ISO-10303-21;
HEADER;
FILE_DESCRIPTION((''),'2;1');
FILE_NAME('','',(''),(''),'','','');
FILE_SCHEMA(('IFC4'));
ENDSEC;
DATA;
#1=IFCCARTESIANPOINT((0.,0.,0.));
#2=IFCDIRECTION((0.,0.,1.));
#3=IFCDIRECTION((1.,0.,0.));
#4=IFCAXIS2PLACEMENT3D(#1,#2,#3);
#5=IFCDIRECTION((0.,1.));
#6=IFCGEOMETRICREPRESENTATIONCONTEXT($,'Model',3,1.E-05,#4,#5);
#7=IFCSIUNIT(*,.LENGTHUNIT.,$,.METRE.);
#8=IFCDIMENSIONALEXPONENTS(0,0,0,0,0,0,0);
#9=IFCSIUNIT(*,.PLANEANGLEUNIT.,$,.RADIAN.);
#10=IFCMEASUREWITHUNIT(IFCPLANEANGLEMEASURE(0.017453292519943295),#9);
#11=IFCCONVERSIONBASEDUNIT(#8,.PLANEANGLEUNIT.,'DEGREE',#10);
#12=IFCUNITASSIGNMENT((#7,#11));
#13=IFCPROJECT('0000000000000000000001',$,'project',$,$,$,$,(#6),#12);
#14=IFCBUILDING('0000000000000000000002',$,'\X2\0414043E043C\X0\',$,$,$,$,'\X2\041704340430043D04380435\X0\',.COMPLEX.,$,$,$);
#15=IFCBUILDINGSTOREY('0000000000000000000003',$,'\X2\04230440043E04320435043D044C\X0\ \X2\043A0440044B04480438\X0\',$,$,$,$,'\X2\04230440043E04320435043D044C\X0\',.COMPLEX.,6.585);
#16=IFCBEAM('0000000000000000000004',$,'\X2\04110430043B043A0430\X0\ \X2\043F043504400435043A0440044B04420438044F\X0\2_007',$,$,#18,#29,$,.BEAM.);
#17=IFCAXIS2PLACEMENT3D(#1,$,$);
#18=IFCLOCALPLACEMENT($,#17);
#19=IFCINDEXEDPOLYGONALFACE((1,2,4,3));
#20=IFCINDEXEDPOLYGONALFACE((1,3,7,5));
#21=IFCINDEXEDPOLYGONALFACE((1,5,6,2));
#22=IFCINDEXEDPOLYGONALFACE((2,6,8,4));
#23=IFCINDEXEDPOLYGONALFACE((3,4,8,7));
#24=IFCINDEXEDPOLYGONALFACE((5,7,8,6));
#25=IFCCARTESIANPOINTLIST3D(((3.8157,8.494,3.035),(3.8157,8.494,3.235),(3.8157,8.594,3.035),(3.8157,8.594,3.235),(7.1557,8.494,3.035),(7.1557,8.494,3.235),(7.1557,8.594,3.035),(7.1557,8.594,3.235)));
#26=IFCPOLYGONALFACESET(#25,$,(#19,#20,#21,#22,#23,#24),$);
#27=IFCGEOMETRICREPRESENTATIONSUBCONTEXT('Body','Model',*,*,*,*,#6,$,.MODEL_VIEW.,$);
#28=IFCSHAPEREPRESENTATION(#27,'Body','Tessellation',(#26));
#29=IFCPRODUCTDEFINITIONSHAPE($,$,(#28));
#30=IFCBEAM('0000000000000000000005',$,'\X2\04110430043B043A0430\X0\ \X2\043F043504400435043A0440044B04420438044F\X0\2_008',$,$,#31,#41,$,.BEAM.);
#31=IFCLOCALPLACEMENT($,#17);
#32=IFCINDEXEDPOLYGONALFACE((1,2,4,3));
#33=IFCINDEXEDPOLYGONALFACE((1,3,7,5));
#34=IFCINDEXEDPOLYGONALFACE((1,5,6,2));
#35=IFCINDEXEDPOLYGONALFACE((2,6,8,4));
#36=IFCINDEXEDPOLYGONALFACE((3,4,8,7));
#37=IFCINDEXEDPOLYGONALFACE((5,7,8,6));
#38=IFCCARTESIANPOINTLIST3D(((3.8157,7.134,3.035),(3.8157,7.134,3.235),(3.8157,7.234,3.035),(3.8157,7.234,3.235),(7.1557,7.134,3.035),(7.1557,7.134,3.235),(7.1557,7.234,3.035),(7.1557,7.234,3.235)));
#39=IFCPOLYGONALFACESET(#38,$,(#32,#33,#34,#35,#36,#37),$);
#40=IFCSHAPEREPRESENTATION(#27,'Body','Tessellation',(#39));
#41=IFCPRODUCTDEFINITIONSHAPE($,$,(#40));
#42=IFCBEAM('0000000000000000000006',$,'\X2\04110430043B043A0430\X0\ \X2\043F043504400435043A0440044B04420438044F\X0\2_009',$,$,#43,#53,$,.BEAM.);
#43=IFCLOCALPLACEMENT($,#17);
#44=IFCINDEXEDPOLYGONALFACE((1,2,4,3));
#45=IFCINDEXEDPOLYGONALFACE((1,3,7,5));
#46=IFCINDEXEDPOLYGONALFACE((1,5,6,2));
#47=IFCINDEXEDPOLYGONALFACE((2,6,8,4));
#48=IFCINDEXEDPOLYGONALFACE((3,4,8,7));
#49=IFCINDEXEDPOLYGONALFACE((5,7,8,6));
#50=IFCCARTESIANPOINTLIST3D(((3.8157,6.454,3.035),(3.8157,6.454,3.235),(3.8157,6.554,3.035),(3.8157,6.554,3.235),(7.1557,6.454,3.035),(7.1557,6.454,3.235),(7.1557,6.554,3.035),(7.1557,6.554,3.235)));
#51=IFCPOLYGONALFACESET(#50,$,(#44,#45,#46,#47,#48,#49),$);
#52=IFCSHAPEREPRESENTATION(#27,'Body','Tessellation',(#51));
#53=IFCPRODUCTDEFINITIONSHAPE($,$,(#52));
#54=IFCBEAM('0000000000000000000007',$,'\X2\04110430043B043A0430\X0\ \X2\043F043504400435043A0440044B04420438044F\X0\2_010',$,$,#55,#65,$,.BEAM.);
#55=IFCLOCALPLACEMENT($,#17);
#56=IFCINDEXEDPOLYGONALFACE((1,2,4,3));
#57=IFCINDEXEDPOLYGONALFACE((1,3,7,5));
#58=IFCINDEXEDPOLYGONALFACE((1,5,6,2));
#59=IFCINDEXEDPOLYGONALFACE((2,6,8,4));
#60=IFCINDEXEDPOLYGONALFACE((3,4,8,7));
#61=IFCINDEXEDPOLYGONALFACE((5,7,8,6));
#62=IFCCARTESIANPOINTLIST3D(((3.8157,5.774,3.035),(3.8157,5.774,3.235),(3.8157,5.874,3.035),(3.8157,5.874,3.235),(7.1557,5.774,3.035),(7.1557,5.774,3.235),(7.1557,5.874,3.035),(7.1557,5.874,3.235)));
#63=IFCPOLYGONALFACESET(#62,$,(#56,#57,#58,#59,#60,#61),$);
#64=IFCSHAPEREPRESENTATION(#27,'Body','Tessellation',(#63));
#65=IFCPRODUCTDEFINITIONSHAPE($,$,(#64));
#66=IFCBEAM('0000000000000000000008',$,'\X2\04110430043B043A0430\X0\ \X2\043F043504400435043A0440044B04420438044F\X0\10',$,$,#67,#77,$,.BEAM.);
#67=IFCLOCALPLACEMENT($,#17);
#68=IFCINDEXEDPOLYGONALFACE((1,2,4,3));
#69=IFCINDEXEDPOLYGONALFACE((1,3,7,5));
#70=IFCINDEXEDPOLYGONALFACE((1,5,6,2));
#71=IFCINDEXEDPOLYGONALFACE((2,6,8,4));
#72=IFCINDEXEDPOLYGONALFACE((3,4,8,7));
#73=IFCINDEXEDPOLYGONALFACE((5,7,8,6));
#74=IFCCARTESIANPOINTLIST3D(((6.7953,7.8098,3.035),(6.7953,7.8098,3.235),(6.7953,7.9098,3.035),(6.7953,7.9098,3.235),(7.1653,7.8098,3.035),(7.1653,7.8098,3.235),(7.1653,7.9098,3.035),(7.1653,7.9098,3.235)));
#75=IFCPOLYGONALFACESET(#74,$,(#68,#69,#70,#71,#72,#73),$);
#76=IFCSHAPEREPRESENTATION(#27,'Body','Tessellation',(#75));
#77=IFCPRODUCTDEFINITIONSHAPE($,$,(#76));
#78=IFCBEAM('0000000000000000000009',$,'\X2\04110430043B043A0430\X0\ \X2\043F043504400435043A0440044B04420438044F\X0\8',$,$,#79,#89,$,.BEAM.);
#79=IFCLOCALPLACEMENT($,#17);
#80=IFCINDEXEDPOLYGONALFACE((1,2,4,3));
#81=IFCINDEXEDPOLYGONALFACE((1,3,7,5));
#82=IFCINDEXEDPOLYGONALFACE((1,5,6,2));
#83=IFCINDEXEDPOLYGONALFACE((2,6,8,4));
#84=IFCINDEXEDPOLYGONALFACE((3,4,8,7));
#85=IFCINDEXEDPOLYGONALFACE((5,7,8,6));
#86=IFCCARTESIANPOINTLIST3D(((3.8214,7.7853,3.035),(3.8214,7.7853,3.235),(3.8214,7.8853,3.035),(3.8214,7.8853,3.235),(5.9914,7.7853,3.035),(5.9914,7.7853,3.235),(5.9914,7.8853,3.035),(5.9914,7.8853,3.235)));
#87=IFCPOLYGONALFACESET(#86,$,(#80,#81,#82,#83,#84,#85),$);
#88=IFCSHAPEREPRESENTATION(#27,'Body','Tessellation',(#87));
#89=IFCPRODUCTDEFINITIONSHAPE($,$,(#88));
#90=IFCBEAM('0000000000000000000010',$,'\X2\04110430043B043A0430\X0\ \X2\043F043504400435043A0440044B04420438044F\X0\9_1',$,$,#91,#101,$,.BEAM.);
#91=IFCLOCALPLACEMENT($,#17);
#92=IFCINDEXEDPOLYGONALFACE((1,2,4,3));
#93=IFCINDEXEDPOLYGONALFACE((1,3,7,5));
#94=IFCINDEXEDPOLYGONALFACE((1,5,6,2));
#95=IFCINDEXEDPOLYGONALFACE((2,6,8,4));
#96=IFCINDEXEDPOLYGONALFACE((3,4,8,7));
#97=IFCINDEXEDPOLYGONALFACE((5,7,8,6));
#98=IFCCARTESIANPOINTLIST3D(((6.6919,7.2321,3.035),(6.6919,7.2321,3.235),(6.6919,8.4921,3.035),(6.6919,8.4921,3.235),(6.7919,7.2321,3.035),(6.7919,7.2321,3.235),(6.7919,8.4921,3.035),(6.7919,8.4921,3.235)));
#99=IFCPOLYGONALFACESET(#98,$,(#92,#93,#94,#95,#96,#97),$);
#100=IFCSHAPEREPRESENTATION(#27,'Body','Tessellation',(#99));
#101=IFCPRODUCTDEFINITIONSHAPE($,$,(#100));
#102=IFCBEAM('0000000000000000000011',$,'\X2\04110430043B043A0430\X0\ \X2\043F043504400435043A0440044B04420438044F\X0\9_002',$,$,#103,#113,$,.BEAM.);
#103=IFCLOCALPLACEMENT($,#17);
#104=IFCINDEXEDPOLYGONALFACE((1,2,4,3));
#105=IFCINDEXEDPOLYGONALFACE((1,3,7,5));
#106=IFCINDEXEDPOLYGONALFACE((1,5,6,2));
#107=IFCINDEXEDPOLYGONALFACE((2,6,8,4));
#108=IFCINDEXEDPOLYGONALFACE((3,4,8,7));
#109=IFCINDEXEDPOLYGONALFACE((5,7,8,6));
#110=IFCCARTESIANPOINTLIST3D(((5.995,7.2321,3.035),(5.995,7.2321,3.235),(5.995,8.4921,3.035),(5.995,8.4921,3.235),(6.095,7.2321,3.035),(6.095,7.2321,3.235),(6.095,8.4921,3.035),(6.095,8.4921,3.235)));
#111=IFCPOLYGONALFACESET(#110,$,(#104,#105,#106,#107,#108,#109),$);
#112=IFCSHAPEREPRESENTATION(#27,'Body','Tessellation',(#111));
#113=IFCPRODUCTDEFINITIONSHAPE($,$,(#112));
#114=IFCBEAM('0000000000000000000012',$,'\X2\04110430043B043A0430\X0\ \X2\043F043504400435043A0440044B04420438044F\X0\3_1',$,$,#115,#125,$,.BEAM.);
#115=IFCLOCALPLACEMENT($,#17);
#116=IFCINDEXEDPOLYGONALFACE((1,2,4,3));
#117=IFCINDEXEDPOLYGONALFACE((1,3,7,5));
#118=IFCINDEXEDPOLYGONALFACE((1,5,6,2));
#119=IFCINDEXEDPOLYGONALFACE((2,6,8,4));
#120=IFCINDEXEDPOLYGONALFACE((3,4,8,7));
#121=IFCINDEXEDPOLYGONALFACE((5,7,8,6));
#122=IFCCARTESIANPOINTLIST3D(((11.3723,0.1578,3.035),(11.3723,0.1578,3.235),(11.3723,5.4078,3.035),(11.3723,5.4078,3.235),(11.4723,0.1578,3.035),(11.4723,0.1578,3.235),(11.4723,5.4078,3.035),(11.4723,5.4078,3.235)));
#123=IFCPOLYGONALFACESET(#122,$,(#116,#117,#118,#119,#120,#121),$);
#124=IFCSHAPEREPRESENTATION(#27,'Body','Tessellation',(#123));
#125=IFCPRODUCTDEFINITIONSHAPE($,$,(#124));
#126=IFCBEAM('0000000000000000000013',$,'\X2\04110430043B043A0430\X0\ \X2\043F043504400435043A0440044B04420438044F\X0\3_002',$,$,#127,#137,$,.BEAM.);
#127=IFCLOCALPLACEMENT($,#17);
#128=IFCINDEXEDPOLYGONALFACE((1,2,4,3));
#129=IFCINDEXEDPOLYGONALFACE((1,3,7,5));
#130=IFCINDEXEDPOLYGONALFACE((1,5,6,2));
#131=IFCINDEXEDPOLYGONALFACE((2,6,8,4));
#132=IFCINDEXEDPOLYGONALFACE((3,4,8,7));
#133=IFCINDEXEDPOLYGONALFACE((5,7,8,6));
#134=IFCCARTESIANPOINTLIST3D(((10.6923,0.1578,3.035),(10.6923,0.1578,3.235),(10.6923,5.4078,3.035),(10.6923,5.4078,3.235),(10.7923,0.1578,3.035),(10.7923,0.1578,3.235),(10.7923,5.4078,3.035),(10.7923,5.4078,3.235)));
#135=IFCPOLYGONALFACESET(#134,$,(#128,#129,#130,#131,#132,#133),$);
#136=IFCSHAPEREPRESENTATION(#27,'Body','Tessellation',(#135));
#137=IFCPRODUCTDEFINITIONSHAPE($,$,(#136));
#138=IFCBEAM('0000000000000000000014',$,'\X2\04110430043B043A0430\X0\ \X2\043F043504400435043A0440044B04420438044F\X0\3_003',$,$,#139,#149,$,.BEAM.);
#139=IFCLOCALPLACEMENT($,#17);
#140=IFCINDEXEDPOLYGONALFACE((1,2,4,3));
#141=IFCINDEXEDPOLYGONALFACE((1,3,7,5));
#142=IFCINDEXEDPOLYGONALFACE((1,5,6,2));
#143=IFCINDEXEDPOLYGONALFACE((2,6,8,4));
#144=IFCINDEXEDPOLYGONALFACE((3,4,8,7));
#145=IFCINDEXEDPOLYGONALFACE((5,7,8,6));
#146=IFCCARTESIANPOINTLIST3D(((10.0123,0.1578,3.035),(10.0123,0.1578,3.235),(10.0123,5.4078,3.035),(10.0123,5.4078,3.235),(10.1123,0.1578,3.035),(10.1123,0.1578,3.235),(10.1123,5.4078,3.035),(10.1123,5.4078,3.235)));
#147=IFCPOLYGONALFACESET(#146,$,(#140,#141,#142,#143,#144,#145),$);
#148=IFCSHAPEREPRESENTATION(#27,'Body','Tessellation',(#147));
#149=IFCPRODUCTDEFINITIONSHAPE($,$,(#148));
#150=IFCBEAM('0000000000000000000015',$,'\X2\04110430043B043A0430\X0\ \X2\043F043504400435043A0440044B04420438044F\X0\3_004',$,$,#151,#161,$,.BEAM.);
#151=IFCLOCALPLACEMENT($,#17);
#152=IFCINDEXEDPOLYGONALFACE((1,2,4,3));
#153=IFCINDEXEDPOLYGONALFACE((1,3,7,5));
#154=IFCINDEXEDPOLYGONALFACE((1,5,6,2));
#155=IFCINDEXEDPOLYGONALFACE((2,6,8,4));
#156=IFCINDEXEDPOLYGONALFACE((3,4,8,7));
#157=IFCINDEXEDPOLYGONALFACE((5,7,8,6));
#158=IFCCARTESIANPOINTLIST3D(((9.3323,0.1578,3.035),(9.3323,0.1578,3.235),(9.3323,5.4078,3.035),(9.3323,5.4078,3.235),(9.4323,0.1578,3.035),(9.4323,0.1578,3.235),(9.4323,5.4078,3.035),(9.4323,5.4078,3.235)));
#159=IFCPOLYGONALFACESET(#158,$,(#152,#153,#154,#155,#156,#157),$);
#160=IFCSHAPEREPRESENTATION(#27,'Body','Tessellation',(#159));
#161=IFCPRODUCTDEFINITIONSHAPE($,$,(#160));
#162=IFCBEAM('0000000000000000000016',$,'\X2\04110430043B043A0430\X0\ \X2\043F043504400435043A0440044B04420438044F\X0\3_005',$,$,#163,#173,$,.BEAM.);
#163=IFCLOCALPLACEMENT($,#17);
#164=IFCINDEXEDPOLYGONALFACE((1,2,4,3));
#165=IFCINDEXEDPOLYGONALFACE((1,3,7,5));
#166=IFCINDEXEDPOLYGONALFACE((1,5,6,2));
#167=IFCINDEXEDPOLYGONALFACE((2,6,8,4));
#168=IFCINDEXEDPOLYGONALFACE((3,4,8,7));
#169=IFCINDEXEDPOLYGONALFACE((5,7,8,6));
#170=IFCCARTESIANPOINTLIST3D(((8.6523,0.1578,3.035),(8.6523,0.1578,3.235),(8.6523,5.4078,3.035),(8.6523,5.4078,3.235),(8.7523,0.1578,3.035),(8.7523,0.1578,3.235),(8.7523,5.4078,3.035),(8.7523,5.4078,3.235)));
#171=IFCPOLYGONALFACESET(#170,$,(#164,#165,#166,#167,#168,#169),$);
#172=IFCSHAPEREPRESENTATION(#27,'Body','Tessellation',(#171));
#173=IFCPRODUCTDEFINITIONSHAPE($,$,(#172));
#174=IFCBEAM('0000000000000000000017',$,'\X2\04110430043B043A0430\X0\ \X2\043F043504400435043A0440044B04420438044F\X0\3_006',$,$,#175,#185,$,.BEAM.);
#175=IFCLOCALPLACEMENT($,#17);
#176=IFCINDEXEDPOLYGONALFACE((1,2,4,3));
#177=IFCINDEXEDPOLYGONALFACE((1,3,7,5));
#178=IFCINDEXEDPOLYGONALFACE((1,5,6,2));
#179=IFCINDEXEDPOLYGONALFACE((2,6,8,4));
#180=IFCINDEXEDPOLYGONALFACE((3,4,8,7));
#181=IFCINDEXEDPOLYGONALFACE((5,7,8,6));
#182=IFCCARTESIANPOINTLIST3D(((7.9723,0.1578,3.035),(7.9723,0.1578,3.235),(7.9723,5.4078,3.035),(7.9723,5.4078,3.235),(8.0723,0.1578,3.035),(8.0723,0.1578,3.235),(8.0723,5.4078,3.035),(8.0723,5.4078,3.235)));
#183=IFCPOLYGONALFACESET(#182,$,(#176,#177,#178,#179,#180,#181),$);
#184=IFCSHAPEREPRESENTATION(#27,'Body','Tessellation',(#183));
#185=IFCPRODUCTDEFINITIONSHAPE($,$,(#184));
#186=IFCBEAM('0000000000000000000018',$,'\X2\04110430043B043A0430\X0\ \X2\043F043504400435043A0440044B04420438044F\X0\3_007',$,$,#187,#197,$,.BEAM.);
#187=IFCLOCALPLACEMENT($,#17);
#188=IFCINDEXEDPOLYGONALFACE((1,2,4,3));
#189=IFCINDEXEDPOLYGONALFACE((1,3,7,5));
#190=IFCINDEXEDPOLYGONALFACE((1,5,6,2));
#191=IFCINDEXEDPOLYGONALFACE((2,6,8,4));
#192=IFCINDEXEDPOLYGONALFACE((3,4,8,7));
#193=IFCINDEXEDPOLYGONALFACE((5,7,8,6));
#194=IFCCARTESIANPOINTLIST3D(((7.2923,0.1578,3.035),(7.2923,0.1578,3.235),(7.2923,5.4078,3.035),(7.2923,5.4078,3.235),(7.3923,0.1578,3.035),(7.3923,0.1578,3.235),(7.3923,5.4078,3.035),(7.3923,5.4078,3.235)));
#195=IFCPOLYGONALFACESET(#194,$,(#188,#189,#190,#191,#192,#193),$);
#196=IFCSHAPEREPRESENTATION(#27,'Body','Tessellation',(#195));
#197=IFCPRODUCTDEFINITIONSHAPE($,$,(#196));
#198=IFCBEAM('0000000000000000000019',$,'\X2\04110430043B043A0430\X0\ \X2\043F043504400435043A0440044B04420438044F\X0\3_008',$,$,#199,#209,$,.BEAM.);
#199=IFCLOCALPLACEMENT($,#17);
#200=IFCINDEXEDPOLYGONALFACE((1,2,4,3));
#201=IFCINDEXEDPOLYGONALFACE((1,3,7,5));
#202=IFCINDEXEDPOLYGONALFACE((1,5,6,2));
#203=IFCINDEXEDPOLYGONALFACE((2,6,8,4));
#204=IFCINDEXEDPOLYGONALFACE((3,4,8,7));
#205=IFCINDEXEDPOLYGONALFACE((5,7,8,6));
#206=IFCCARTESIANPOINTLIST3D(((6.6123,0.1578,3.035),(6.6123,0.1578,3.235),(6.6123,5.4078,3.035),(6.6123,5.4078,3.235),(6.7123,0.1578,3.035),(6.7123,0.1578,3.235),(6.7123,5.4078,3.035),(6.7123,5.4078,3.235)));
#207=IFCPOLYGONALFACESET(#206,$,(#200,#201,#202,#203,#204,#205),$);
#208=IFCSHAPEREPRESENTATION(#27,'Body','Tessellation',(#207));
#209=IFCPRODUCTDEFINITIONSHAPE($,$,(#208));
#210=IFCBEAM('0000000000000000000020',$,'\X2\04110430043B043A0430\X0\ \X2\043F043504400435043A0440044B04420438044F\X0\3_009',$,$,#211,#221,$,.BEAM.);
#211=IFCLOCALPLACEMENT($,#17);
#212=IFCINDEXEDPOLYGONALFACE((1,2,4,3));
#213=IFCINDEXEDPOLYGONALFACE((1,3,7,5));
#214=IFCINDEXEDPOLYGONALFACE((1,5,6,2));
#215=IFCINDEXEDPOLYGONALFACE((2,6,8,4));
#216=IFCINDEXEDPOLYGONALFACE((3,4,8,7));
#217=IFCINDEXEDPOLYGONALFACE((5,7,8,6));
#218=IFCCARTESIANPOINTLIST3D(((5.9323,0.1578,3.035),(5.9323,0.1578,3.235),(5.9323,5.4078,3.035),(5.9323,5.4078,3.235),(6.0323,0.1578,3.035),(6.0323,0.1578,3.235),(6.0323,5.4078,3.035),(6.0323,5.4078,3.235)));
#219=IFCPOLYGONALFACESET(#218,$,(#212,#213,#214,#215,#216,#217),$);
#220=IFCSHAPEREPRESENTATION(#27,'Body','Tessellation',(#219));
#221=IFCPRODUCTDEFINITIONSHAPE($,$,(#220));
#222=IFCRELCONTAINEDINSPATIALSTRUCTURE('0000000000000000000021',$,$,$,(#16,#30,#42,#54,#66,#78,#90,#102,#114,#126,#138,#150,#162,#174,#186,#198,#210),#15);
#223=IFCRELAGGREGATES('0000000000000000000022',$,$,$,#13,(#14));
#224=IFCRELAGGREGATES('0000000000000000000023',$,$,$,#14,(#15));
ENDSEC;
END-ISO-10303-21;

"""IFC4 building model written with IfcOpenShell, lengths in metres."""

from ifc_helpers import new_model, entity, si_unit, converted_unit, direction, frame, frame_2d, origin_with_axes, origin_2d_with_axis, place, context, subcontext, project, spatial, rectangle, extrude, element, save


model = new_model("IFC4")

# Units and contexts
model_context = context("Model", 3, precision=1e-05, world=origin_with_axes(), true_north=direction((0.0, 1.0)))
body_context = subcontext(model_context, "Body", "Model", "MODEL_VIEW")
ifc_project = project(units=[si_unit("LENGTHUNIT", "METRE"), converted_unit("PLANEANGLEUNIT", "DEGREE", entity("IfcPlaneAngleMeasure", 0.017453292519943295), si_unit("PLANEANGLEUNIT", "RADIAN"), dimensions=[0, 0, 0, 0, 0, 0, 0])], contexts=[model_context])

# Building, storey
building = spatial("IfcBuilding", under=ifc_project, Name="Дом", LongName="Здание", CompositionType="COMPLEX")
storey = spatial("IfcBuildingStorey", under=building, Name="Уровень крыши", LongName="Уровень", CompositionType="COMPLEX", Elevation=6.585)

# Beams
placement = place(None, origin_with_axes())
element("IfcBeam", 1, at=placement, inside=storey, Name="Балка перекрытия2_007", PredefinedType="BEAM", context=body_context, shape_type="SweptSolid", body=[
    extrude(rectangle(XDim=3.34, YDim=0.1, at=frame_2d((0.0, 0.0), x_axis=(1.0, 0.0))), frame((5.4857, 8.544, 3.035), z_axis=(0.0, 0.0, 1.0), x_axis=(1.0, 0.0, 0.0)), (0.0, 0.0, 1.0), 0.2),
])
element("IfcBeam", 2, at=placement, inside=storey, Name="Балка перекрытия2_008", PredefinedType="BEAM", context=body_context, shape_type="SweptSolid", body=[
    extrude(rectangle(XDim=3.34, YDim=0.1, at=frame_2d((0.0, 0.0), x_axis=(1.0, 0.0))), frame((5.4857, 7.184, 3.035), z_axis=(0.0, 0.0, 1.0), x_axis=(1.0, 0.0, 0.0)), (0.0, 0.0, 1.0), 0.2),
])
element("IfcBeam", 3, at=placement, inside=storey, Name="Балка перекрытия2_009", PredefinedType="BEAM", context=body_context, shape_type="SweptSolid", body=[
    extrude(rectangle(XDim=3.34, YDim=0.1, at=frame_2d((0.0, 0.0), x_axis=(1.0, 0.0))), frame((5.4857, 6.504, 3.035), z_axis=(0.0, 0.0, 1.0), x_axis=(1.0, 0.0, 0.0)), (0.0, 0.0, 1.0), 0.2),
])
element("IfcBeam", 4, at=placement, inside=storey, Name="Балка перекрытия2_010", PredefinedType="BEAM", context=body_context, shape_type="SweptSolid", body=[
    extrude(rectangle(XDim=3.34, YDim=0.1, at=frame_2d((0.0, 0.0), x_axis=(1.0, 0.0))), frame((5.4857, 5.824, 3.035), z_axis=(0.0, 0.0, 1.0), x_axis=(1.0, 0.0, 0.0)), (0.0, 0.0, 1.0), 0.2),
])
element("IfcBeam", 5, at=placement, inside=storey, Name="Балка перекрытия10", PredefinedType="BEAM", context=body_context, shape_type="SweptSolid", body=[
    extrude(rectangle(XDim=0.37, YDim=0.1, at=origin_2d_with_axis()), frame((6.9803, 7.8598, 3.035), z_axis=(0.0, 0.0, 1.0), x_axis=(1.0, 0.0, 0.0)), (0.0, 0.0, 1.0), 0.2),
])
element("IfcBeam", 6, at=placement, inside=storey, Name="Балка перекрытия8", PredefinedType="BEAM", context=body_context, shape_type="SweptSolid", body=[
    extrude(rectangle(XDim=2.17, YDim=0.1, at=origin_2d_with_axis()), frame((4.9064, 7.8353, 3.035), z_axis=(0.0, 0.0, 1.0), x_axis=(1.0, 0.0, 0.0)), (0.0, 0.0, 1.0), 0.2),
])
element("IfcBeam", 7, at=placement, inside=storey, Name="Балка перекрытия9_1", PredefinedType="BEAM", context=body_context, shape_type="SweptSolid", body=[
    extrude(rectangle(XDim=0.1, YDim=1.26, at=origin_2d_with_axis()), frame((6.7419, 7.8621, 3.035), z_axis=(0.0, 0.0, 1.0), x_axis=(1.0, 0.0, 0.0)), (0.0, 0.0, 1.0), 0.2),
])
element("IfcBeam", 8, at=placement, inside=storey, Name="Балка перекрытия9_002", PredefinedType="BEAM", context=body_context, shape_type="SweptSolid", body=[
    extrude(rectangle(XDim=0.1, YDim=1.26, at=origin_2d_with_axis()), frame((6.045, 7.8621, 3.035), z_axis=(0.0, 0.0, 1.0), x_axis=(1.0, 0.0, 0.0)), (0.0, 0.0, 1.0), 0.2),
])
element("IfcBeam", 9, at=placement, inside=storey, Name="Балка перекрытия3_1", PredefinedType="BEAM", context=body_context, shape_type="SweptSolid", body=[
    extrude(rectangle(XDim=0.1, YDim=5.25, at=origin_2d_with_axis()), frame((11.4223, 2.7828, 3.035), z_axis=(0.0, 0.0, 1.0), x_axis=(1.0, 0.0, 0.0)), (0.0, 0.0, 1.0), 0.2),
])
element("IfcBeam", 10, at=placement, inside=storey, Name="Балка перекрытия3_002", PredefinedType="BEAM", context=body_context, shape_type="SweptSolid", body=[
    extrude(rectangle(XDim=0.1, YDim=5.25, at=origin_2d_with_axis()), frame((10.7423, 2.7828, 3.035), z_axis=(0.0, 0.0, 1.0), x_axis=(1.0, 0.0, 0.0)), (0.0, 0.0, 1.0), 0.2),
])
element("IfcBeam", 11, at=placement, inside=storey, Name="Балка перекрытия3_003", PredefinedType="BEAM", context=body_context, shape_type="SweptSolid", body=[
    extrude(rectangle(XDim=0.1, YDim=5.25, at=origin_2d_with_axis()), frame((10.0623, 2.7828, 3.035), z_axis=(0.0, 0.0, 1.0), x_axis=(1.0, 0.0, 0.0)), (0.0, 0.0, 1.0), 0.2),
])
element("IfcBeam", 12, at=placement, inside=storey, Name="Балка перекрытия3_004", PredefinedType="BEAM", context=body_context, shape_type="SweptSolid", body=[
    extrude(rectangle(XDim=0.1, YDim=5.25, at=origin_2d_with_axis()), frame((9.3823, 2.7828, 3.035), z_axis=(0.0, 0.0, 1.0), x_axis=(1.0, 0.0, 0.0)), (0.0, 0.0, 1.0), 0.2),
])
element("IfcBeam", 13, at=placement, inside=storey, Name="Балка перекрытия3_005", PredefinedType="BEAM", context=body_context, shape_type="SweptSolid", body=[
    extrude(rectangle(XDim=0.1, YDim=5.25, at=origin_2d_with_axis()), frame((8.7023, 2.7828, 3.035), z_axis=(0.0, 0.0, 1.0), x_axis=(1.0, 0.0, 0.0)), (0.0, 0.0, 1.0), 0.2),
])
element("IfcBeam", 14, at=placement, inside=storey, Name="Балка перекрытия3_006", PredefinedType="BEAM", context=body_context, shape_type="SweptSolid", body=[
    extrude(rectangle(XDim=0.1, YDim=5.25, at=origin_2d_with_axis()), frame((8.0223, 2.7828, 3.035), z_axis=(0.0, 0.0, 1.0), x_axis=(1.0, 0.0, 0.0)), (0.0, 0.0, 1.0), 0.2),
])
element("IfcBeam", 15, at=placement, inside=storey, Name="Балка перекрытия3_007", PredefinedType="BEAM", context=body_context, shape_type="SweptSolid", body=[
    extrude(rectangle(XDim=0.1, YDim=5.25, at=origin_2d_with_axis()), frame((7.3423, 2.7828, 3.035), z_axis=(0.0, 0.0, 1.0), x_axis=(1.0, 0.0, 0.0)), (0.0, 0.0, 1.0), 0.2),
])
element("IfcBeam", 16, at=placement, inside=storey, Name="Балка перекрытия3_008", PredefinedType="BEAM", context=body_context, shape_type="SweptSolid", body=[
    extrude(rectangle(XDim=0.1, YDim=5.25, at=origin_2d_with_axis()), frame((6.6623, 2.7828, 3.035), z_axis=(0.0, 0.0, 1.0), x_axis=(1.0, 0.0, 0.0)), (0.0, 0.0, 1.0), 0.2),
])
element("IfcBeam", 17, at=placement, inside=storey, Name="Балка перекрытия3_009", PredefinedType="BEAM", context=body_context, shape_type="SweptSolid", body=[
    extrude(rectangle(XDim=0.1, YDim=5.25, at=origin_2d_with_axis()), frame((5.9823, 2.7828, 3.035), z_axis=(0.0, 0.0, 1.0), x_axis=(1.0, 0.0, 0.0)), (0.0, 0.0, 1.0), 0.2),
])

save(model, "model.ifc")
